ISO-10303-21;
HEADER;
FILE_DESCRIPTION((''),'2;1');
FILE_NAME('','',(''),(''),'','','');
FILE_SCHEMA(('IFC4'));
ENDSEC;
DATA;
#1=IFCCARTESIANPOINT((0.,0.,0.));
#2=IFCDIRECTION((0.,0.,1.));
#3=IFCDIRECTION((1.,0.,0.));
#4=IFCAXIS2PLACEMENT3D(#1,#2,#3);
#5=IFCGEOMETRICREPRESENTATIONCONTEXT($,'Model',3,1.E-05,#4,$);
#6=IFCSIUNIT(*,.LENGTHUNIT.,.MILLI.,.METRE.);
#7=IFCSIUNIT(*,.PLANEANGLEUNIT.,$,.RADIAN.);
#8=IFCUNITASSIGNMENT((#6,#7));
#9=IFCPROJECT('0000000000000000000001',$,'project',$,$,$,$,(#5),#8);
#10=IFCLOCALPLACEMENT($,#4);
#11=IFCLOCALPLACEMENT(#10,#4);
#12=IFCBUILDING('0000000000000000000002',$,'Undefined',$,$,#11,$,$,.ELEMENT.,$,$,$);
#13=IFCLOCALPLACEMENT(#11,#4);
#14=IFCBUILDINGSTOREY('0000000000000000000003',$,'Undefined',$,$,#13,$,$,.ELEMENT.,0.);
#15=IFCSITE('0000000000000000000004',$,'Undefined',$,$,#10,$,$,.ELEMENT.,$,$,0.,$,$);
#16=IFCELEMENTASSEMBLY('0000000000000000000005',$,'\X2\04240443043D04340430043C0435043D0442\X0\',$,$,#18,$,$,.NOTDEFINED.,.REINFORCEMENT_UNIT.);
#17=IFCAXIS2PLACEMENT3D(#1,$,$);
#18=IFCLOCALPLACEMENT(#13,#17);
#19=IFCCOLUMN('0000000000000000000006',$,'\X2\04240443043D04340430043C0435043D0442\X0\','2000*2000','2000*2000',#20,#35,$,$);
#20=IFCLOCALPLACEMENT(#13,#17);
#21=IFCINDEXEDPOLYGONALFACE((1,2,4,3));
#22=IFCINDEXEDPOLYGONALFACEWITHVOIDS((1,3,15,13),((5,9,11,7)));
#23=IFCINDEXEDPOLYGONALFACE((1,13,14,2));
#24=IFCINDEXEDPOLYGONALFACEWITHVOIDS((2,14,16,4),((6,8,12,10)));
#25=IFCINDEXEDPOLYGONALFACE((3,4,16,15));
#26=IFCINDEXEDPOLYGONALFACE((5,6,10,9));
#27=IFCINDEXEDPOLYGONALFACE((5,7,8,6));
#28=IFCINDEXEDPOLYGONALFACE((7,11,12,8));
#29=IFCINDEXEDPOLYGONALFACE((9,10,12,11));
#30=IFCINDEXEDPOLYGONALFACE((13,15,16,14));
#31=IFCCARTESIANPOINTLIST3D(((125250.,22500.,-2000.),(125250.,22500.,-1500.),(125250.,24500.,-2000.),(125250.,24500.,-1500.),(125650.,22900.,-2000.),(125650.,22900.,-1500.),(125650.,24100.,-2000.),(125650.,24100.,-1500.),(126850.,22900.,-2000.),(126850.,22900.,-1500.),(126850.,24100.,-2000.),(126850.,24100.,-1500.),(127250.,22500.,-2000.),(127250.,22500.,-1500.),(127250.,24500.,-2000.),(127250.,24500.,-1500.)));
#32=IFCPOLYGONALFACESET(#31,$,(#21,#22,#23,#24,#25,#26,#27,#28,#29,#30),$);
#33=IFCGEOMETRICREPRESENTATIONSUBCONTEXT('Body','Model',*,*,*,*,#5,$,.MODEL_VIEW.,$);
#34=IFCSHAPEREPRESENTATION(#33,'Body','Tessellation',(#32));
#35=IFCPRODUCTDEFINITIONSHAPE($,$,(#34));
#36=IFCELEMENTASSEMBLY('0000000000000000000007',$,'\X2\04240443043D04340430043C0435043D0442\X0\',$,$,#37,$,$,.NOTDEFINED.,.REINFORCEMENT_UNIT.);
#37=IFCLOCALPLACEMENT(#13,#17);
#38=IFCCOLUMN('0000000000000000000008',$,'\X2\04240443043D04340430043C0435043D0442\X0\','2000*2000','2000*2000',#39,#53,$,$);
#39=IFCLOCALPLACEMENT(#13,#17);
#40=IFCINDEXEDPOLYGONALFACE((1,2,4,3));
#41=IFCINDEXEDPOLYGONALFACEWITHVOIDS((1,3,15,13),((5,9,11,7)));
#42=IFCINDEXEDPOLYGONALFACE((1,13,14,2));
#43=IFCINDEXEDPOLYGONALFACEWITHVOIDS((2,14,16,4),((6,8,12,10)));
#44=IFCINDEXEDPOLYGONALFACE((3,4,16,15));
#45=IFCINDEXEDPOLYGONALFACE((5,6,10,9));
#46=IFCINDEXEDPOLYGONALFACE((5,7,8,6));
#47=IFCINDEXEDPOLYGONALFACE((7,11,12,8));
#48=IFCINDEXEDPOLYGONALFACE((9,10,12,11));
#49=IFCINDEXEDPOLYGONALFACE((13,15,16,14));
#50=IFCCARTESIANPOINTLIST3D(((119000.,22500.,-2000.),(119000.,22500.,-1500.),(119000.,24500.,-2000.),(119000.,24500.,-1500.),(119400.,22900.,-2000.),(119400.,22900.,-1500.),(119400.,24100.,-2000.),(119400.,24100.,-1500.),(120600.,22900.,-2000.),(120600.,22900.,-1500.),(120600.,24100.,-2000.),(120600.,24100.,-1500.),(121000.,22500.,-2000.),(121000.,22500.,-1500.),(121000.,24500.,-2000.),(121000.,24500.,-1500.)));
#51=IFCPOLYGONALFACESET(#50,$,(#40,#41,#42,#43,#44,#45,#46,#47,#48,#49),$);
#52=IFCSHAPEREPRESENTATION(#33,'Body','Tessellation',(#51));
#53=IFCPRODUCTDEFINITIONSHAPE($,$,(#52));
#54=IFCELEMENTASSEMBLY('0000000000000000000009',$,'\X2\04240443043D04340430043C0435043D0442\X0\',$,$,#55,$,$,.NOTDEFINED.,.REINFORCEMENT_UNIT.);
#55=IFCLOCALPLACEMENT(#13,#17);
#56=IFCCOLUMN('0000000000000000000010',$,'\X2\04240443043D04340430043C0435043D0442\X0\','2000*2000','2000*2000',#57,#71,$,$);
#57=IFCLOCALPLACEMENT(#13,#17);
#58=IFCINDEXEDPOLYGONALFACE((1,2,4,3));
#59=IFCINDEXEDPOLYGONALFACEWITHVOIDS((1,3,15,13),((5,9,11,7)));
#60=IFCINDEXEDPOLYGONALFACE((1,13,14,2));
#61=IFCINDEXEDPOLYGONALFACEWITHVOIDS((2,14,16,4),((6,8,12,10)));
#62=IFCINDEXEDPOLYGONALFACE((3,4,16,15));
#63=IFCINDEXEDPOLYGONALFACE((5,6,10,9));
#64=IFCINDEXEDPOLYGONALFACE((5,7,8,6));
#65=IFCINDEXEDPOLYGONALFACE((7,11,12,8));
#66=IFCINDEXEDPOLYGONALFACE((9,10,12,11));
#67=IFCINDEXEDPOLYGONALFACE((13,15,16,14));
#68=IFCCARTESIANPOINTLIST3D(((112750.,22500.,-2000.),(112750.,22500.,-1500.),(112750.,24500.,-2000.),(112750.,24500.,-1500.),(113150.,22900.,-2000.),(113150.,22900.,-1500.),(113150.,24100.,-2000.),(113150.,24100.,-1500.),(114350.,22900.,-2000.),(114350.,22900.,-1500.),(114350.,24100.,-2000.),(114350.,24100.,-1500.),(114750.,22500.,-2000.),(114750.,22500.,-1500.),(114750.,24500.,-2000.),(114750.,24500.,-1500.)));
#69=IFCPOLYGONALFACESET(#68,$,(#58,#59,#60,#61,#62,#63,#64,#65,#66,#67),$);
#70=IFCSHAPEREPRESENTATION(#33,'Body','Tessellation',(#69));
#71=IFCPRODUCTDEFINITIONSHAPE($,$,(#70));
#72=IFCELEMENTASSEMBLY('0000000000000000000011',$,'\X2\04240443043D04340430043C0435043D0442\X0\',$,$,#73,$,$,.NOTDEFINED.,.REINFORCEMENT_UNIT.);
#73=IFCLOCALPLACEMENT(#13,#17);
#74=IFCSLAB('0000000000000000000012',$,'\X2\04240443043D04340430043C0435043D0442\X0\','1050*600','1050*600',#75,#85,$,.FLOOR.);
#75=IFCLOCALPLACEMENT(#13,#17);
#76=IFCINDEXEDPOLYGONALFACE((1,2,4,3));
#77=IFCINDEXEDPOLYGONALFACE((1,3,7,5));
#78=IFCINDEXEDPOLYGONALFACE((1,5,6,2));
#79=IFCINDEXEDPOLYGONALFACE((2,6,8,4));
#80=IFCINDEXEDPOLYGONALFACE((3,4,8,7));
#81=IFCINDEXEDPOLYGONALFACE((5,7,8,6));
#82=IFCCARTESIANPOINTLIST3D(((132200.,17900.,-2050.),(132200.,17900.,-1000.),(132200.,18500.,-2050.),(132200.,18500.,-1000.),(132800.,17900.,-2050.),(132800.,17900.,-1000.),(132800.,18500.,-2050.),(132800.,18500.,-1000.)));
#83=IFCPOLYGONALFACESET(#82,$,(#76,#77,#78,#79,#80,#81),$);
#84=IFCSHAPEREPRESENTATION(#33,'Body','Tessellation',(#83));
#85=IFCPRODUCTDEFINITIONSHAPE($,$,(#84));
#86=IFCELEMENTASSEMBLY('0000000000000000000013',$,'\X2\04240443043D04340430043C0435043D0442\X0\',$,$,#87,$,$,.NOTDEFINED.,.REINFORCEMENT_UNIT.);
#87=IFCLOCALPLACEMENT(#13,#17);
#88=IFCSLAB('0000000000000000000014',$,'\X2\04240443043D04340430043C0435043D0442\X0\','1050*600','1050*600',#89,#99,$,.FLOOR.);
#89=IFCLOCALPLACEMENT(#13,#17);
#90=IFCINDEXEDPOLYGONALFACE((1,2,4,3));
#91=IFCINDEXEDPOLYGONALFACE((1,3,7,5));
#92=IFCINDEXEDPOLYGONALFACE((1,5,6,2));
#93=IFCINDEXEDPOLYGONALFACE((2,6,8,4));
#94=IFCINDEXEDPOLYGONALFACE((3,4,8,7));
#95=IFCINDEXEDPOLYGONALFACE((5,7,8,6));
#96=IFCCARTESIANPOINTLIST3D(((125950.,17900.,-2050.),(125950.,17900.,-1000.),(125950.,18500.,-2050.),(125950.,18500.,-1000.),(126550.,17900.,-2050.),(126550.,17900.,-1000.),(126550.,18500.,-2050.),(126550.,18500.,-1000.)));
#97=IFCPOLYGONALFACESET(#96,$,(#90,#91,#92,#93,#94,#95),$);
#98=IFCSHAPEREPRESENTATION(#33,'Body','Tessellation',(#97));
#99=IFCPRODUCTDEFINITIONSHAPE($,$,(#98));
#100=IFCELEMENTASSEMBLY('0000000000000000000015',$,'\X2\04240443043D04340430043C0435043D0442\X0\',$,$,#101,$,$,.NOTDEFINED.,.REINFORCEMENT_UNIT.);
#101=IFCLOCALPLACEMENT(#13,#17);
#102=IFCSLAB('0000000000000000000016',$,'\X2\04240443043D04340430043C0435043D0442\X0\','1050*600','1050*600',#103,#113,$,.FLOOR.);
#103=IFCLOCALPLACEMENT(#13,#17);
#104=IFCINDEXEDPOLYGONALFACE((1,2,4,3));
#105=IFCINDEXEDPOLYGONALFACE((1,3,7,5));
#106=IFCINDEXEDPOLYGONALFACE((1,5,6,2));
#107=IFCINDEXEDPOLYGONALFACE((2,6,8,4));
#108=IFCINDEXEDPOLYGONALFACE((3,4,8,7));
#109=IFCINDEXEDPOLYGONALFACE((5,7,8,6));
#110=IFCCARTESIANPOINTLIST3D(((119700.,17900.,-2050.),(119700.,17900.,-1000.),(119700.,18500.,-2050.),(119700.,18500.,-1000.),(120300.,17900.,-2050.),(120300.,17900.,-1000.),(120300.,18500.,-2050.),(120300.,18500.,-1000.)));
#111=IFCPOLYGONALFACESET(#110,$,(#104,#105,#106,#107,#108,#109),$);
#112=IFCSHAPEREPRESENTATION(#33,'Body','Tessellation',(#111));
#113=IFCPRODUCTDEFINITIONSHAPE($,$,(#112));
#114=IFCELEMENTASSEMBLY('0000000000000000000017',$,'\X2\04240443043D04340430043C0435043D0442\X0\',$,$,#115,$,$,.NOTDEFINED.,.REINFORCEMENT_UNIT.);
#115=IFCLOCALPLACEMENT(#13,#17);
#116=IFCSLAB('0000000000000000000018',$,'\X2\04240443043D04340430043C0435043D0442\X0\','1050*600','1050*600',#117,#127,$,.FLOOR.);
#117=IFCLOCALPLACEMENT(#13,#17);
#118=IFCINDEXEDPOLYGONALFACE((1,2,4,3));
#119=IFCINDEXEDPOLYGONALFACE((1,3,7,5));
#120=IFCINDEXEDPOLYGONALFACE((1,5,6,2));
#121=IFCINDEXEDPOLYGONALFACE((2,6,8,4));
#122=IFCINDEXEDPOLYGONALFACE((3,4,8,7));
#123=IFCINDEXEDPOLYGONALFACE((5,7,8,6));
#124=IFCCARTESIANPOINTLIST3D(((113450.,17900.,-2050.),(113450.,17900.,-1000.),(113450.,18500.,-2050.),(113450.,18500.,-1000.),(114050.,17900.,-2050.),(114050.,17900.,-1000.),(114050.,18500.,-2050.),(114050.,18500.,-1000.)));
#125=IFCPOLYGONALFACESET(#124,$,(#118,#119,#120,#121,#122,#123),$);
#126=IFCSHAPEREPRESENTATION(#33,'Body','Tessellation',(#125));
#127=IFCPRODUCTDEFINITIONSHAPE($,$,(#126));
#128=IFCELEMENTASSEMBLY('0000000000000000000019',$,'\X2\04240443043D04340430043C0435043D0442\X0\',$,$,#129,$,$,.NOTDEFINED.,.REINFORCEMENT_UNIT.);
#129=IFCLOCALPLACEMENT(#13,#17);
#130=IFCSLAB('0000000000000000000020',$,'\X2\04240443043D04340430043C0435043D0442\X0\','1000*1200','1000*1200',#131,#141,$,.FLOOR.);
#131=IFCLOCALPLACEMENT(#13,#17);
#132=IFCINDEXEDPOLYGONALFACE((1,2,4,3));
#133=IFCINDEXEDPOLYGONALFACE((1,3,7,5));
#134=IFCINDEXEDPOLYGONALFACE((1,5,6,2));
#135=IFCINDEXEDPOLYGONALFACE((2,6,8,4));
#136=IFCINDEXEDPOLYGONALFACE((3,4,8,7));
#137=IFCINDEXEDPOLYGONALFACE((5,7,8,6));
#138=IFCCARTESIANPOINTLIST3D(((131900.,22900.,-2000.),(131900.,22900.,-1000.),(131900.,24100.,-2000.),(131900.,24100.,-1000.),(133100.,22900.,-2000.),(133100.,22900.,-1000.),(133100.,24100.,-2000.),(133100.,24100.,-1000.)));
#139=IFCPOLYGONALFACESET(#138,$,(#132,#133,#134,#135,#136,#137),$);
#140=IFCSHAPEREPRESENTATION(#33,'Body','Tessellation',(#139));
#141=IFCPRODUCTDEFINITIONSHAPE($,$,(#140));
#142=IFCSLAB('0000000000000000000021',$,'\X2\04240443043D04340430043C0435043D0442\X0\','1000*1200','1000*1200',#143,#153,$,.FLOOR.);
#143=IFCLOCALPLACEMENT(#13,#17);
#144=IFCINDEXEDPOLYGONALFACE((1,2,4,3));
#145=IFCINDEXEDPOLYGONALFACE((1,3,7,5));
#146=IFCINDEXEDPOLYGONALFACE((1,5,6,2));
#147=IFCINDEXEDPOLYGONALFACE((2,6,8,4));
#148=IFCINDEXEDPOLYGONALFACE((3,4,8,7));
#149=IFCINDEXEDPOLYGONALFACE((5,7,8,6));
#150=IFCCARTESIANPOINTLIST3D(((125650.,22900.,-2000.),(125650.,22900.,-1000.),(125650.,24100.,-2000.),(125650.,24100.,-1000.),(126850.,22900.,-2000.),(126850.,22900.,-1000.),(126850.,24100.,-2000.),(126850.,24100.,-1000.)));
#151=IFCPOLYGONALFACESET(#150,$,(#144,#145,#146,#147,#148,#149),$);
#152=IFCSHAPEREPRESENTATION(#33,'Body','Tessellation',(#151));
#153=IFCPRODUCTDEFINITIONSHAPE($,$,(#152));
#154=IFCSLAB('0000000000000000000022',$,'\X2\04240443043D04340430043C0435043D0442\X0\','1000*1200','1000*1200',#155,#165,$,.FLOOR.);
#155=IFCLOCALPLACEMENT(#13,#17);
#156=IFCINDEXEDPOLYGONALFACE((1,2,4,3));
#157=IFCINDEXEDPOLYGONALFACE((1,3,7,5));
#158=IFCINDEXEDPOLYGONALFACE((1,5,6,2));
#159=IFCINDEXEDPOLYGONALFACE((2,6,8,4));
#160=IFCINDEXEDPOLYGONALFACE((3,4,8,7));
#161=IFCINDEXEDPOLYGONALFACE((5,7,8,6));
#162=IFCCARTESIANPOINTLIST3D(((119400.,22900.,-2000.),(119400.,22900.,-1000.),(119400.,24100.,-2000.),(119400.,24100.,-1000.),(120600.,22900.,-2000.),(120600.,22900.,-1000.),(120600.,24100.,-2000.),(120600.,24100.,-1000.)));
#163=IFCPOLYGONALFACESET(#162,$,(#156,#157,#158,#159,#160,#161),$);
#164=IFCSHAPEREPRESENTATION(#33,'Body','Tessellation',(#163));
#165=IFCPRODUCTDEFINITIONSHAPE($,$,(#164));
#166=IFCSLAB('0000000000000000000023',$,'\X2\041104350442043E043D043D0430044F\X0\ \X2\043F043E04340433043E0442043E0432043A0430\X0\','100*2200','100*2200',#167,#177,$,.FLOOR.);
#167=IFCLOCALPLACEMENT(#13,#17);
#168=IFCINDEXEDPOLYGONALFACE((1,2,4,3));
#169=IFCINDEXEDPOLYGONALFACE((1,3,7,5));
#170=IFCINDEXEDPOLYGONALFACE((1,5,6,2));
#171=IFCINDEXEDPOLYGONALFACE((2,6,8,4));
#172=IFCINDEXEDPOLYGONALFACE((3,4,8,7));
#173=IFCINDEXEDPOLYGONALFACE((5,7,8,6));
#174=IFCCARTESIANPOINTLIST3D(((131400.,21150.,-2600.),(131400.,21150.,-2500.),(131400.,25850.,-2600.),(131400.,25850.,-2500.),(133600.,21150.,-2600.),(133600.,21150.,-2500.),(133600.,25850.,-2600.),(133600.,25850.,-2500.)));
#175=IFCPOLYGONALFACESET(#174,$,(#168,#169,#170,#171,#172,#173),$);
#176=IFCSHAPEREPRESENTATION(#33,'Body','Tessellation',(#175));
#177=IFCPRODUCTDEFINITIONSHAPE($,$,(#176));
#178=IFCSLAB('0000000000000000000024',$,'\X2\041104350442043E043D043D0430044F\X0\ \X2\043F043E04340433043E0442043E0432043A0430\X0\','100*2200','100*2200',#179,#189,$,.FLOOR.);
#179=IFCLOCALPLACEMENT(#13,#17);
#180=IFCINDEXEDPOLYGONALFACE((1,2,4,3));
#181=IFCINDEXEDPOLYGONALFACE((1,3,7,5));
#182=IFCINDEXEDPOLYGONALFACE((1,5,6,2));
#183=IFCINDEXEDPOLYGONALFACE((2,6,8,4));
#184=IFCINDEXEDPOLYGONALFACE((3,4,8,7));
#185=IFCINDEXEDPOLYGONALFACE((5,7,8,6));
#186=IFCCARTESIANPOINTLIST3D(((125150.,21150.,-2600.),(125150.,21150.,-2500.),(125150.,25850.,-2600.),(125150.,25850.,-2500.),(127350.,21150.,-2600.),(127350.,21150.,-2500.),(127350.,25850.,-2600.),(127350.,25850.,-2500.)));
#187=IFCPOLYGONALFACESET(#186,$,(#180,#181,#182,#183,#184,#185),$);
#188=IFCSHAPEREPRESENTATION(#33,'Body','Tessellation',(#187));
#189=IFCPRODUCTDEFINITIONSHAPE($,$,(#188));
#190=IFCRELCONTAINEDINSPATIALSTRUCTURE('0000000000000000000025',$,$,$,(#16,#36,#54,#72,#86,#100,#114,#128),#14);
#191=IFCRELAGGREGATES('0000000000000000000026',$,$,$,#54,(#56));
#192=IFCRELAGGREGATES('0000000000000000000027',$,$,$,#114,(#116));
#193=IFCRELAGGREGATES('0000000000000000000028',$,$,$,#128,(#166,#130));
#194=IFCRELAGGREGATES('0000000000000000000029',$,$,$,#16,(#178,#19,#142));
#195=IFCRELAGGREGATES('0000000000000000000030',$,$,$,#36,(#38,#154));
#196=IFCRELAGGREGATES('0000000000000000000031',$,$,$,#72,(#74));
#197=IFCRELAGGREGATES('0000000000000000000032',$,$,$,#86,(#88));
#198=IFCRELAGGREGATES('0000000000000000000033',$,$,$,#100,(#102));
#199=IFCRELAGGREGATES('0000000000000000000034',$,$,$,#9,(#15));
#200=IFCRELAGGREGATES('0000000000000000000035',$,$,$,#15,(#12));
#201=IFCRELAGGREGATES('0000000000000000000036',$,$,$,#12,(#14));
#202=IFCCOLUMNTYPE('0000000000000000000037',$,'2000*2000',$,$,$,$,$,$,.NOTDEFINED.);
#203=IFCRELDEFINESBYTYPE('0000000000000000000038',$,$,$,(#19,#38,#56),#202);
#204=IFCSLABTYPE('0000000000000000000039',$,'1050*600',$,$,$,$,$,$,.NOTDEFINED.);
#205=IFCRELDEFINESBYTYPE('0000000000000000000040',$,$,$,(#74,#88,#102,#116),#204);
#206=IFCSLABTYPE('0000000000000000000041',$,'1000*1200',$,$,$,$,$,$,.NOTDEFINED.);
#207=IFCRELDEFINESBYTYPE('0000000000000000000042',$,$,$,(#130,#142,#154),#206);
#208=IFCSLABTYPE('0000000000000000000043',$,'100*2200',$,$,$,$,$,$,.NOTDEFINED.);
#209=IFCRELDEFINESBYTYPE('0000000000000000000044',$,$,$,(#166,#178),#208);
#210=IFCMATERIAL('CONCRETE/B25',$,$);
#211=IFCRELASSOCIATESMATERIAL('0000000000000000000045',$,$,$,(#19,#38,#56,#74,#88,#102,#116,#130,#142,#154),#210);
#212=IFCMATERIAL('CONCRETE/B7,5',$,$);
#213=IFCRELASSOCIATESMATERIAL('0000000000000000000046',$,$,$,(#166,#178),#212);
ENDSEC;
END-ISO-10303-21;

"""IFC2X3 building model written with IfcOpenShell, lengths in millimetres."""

from ifc_helpers import new_model, si_unit, frame, origin_with_axes, origin_2d_with_axis, place, context, subcontext, project, spatial, polyline, rectangle, outline, extrude, boolean, material, type_object, element, aggregate, save


model = new_model("IFC2X3")

# Units and contexts
model_context = context("Model", 3, precision=1e-05, world=origin_with_axes())
body_context = subcontext(model_context, "Body", "Model", "MODEL_VIEW")
ifc_project = project(units=[si_unit("LENGTHUNIT", "METRE", prefix="MILLI"), si_unit("PLANEANGLEUNIT", "RADIAN")], contexts=[model_context])

# Site, building, storey
site_placement = place(None, origin_with_axes())
site = spatial("IfcSite", under=ifc_project, at=site_placement, Name="Undefined", CompositionType="ELEMENT", RefElevation=0.0)
building_placement = place(site_placement, origin_with_axes())
building = spatial("IfcBuilding", under=site, at=building_placement, Name="Undefined", CompositionType="ELEMENT")
storey_placement = place(building_placement, origin_with_axes())
storey = spatial("IfcBuildingStorey", under=building, at=storey_placement, Name="Undefined", CompositionType="ELEMENT", Elevation=0.0)

# Element assemblies, columns
assembly_1_placement = place(storey_placement, origin_with_axes())
assembly_1 = element("IfcElementAssembly", 1, at=assembly_1_placement, inside=storey, Name="Фундамент", AssemblyPlace="NOTDEFINED", PredefinedType="REINFORCEMENT_UNIT")
ifc_material_1 = material(Name="CONCRETE/B25")
column_type = type_object("IfcColumnType", Name="2000*2000", PredefinedType="NOTDEFINED")
column_1_placement = place(assembly_1_placement, frame((126250.0, 23500.0, -2000.0), z_axis=(0.0, 0.0, 1.0), x_axis=(0.0, -1.0, 0.0)))
column_1 = element("IfcColumn", 2, at=column_1_placement, type_object=column_type, material=ifc_material_1, Name="Фундамент", Description="2000*2000", ObjectType="2000*2000", context=body_context, shape_type="CSG", body=[
    boolean("DIFFERENCE", extrude(rectangle(XDim=2000.0, YDim=2000.0, at=origin_2d_with_axis()), frame((0.0, 0.0, 500.0), z_axis=(0.0, 0.0, -1.0), x_axis=(0.0, 1.0, 0.0)), (0.0, 0.0, 1.0), 500.0), extrude(outline(polyline([(0.0, 0.0), (1200.0, 0.0), (1200.0, 1200.0), (0.0, 1200.0), (0.0, 0.0)])), frame((-600.0, -600.0, -100.0), z_axis=(0.0, 0.0, 1.0), x_axis=(1.0, 0.0, 0.0)), (0.0, 0.0, 1.0), 700.0)),
])
assembly_2_placement = place(storey_placement, origin_with_axes())
assembly_2 = element("IfcElementAssembly", 3, at=assembly_2_placement, inside=storey, Name="Фундамент", AssemblyPlace="NOTDEFINED", PredefinedType="REINFORCEMENT_UNIT")
column_2_placement = place(assembly_2_placement, frame((120000.0, 23500.0, -2000.0), z_axis=(0.0, 0.0, 1.0), x_axis=(0.0, -1.0, 0.0)))
column_2 = element("IfcColumn", 4, at=column_2_placement, type_object=column_type, material=ifc_material_1, Name="Фундамент", Description="2000*2000", ObjectType="2000*2000", context=body_context, shape_type="CSG", body=[
    boolean("DIFFERENCE", extrude(rectangle(XDim=2000.0, YDim=2000.0, at=origin_2d_with_axis()), frame((0.0, 0.0, 500.0), z_axis=(0.0, 0.0, -1.0), x_axis=(0.0, 1.0, 0.0)), (0.0, 0.0, 1.0), 500.0), extrude(outline(polyline([(0.0, 0.0), (1200.0, 0.0), (1200.0, 1200.0), (0.0, 1200.0), (0.0, 0.0)])), frame((-600.0, -600.0, -100.0), z_axis=(0.0, 0.0, 1.0), x_axis=(1.0, 0.0, 0.0)), (0.0, 0.0, 1.0), 700.0)),
])
assembly_3_placement = place(storey_placement, origin_with_axes())
assembly_3 = element("IfcElementAssembly", 5, at=assembly_3_placement, inside=storey, Name="Фундамент", AssemblyPlace="NOTDEFINED", PredefinedType="REINFORCEMENT_UNIT")
column_3_placement = place(assembly_3_placement, frame((113750.0, 23500.0, -2000.0), z_axis=(0.0, 0.0, 1.0), x_axis=(0.0, -1.0, 0.0)))
column_3 = element("IfcColumn", 6, at=column_3_placement, type_object=column_type, material=ifc_material_1, Name="Фундамент", Description="2000*2000", ObjectType="2000*2000", context=body_context, shape_type="CSG", body=[
    boolean("DIFFERENCE", extrude(rectangle(XDim=2000.0, YDim=2000.0, at=origin_2d_with_axis()), frame((0.0, 0.0, 500.0), z_axis=(0.0, 0.0, -1.0), x_axis=(0.0, 1.0, 0.0)), (0.0, 0.0, 1.0), 500.0), extrude(outline(polyline([(0.0, 0.0), (1200.0, 0.0), (1200.0, 1200.0), (0.0, 1200.0), (0.0, 0.0)])), frame((-600.0, -600.0, -100.0), z_axis=(0.0, 0.0, 1.0), x_axis=(1.0, 0.0, 0.0)), (0.0, 0.0, 1.0), 700.0)),
])
aggregate(assembly_3, [column_3])

# Element assemblies, slabs
assembly_4_placement = place(storey_placement, origin_with_axes())
assembly_4 = element("IfcElementAssembly", 7, at=assembly_4_placement, inside=storey, Name="Фундамент", AssemblyPlace="NOTDEFINED", PredefinedType="REINFORCEMENT_UNIT")
slab_type_1 = type_object("IfcSlabType", Name="1050*600", PredefinedType="NOTDEFINED")
slab_1_placement = place(assembly_4_placement, frame((132200.0, 18500.0, -1525.0), z_axis=(0.0, 0.0, 1.0), x_axis=(0.0, -1.0, 0.0)))
slab_1 = element("IfcSlab", 8, at=slab_1_placement, type_object=slab_type_1, material=ifc_material_1, Name="Фундамент", Description="1050*600", ObjectType="1050*600", PredefinedType="FLOOR", context=body_context, shape_type="SweptSolid", body=[
    extrude(outline(polyline([(0.0, 0.0), (600.0, 0.0), (600.0, 600.0), (0.0, 600.0), (0.0, 0.0)])), frame((0.0, 0.0, -525.0), z_axis=(0.0, 0.0, 1.0), x_axis=(1.0, 0.0, 0.0)), (0.0, 0.0, 1.0), 1050.0),
])
assembly_5_placement = place(storey_placement, origin_with_axes())
assembly_5 = element("IfcElementAssembly", 9, at=assembly_5_placement, inside=storey, Name="Фундамент", AssemblyPlace="NOTDEFINED", PredefinedType="REINFORCEMENT_UNIT")
slab_2_placement = place(assembly_5_placement, frame((125950.0, 18500.0, -1525.0), z_axis=(0.0, 0.0, 1.0), x_axis=(0.0, -1.0, 0.0)))
slab_2 = element("IfcSlab", 10, at=slab_2_placement, type_object=slab_type_1, material=ifc_material_1, Name="Фундамент", Description="1050*600", ObjectType="1050*600", PredefinedType="FLOOR", context=body_context, shape_type="SweptSolid", body=[
    extrude(outline(polyline([(0.0, 0.0), (600.0, 0.0), (600.0, 600.0), (0.0, 600.0), (0.0, 0.0)])), frame((0.0, 0.0, -525.0), z_axis=(0.0, 0.0, 1.0), x_axis=(1.0, 0.0, 0.0)), (0.0, 0.0, 1.0), 1050.0),
])
assembly_6_placement = place(storey_placement, origin_with_axes())
assembly_6 = element("IfcElementAssembly", 11, at=assembly_6_placement, inside=storey, Name="Фундамент", AssemblyPlace="NOTDEFINED", PredefinedType="REINFORCEMENT_UNIT")
slab_3_placement = place(assembly_6_placement, frame((119700.0, 18500.0, -1525.0), z_axis=(0.0, 0.0, 1.0), x_axis=(0.0, -1.0, 0.0)))
slab_3 = element("IfcSlab", 12, at=slab_3_placement, type_object=slab_type_1, material=ifc_material_1, Name="Фундамент", Description="1050*600", ObjectType="1050*600", PredefinedType="FLOOR", context=body_context, shape_type="SweptSolid", body=[
    extrude(outline(polyline([(0.0, 0.0), (600.0, 0.0), (600.0, 600.0), (0.0, 600.0), (0.0, 0.0)])), frame((0.0, 0.0, -525.0), z_axis=(0.0, 0.0, 1.0), x_axis=(1.0, 0.0, 0.0)), (0.0, 0.0, 1.0), 1050.0),
])
assembly_7_placement = place(storey_placement, origin_with_axes())
assembly_7 = element("IfcElementAssembly", 13, at=assembly_7_placement, inside=storey, Name="Фундамент", AssemblyPlace="NOTDEFINED", PredefinedType="REINFORCEMENT_UNIT")
slab_4_placement = place(assembly_7_placement, frame((113450.0, 18500.0, -1525.0), z_axis=(0.0, 0.0, 1.0), x_axis=(0.0, -1.0, 0.0)))
slab_4 = element("IfcSlab", 14, at=slab_4_placement, type_object=slab_type_1, material=ifc_material_1, Name="Фундамент", Description="1050*600", ObjectType="1050*600", PredefinedType="FLOOR", context=body_context, shape_type="SweptSolid", body=[
    extrude(outline(polyline([(0.0, 0.0), (600.0, 0.0), (600.0, 600.0), (0.0, 600.0), (0.0, 0.0)])), frame((0.0, 0.0, -525.0), z_axis=(0.0, 0.0, 1.0), x_axis=(1.0, 0.0, 0.0)), (0.0, 0.0, 1.0), 1050.0),
])
aggregate(assembly_7, [slab_4])
assembly_8_placement = place(storey_placement, origin_with_axes())
assembly_8 = element("IfcElementAssembly", 15, at=assembly_8_placement, inside=storey, Name="Фундамент", AssemblyPlace="NOTDEFINED", PredefinedType="REINFORCEMENT_UNIT")
slab_type_2 = type_object("IfcSlabType", Name="1000*1200", PredefinedType="NOTDEFINED")
slab_5_placement = place(assembly_8_placement, frame((131900.0, 24100.0, -1500.0), z_axis=(0.0, 0.0, 1.0), x_axis=(0.0, -1.0, 0.0)))
slab_5 = element("IfcSlab", 16, at=slab_5_placement, type_object=slab_type_2, material=ifc_material_1, Name="Фундамент", Description="1000*1200", ObjectType="1000*1200", PredefinedType="FLOOR", context=body_context, shape_type="SweptSolid", body=[
    extrude(outline(polyline([(0.0, 0.0), (1200.0, 0.0), (1200.0, 1200.0), (0.0, 1200.0), (0.0, 0.0)])), frame((0.0, 0.0, -500.0), z_axis=(0.0, 0.0, 1.0), x_axis=(1.0, 0.0, 0.0)), (0.0, 0.0, 1.0), 1000.0),
])

# Slabs
slab_6_placement = place(assembly_1_placement, frame((125650.0, 24100.0, -1500.0), z_axis=(0.0, 0.0, 1.0), x_axis=(0.0, -1.0, 0.0)))
slab_6 = element("IfcSlab", 17, at=slab_6_placement, type_object=slab_type_2, material=ifc_material_1, Name="Фундамент", Description="1000*1200", ObjectType="1000*1200", PredefinedType="FLOOR", context=body_context, shape_type="SweptSolid", body=[
    extrude(outline(polyline([(0.0, 0.0), (1200.0, 0.0), (1200.0, 1200.0), (0.0, 1200.0), (0.0, 0.0)])), frame((0.0, 0.0, -500.0), z_axis=(0.0, 0.0, 1.0), x_axis=(1.0, 0.0, 0.0)), (0.0, 0.0, 1.0), 1000.0),
])
slab_7_placement = place(assembly_2_placement, frame((119400.0, 24100.0, -1500.0), z_axis=(0.0, 0.0, 1.0), x_axis=(0.0, -1.0, 0.0)))
slab_7 = element("IfcSlab", 18, at=slab_7_placement, type_object=slab_type_2, material=ifc_material_1, Name="Фундамент", Description="1000*1200", ObjectType="1000*1200", PredefinedType="FLOOR", context=body_context, shape_type="SweptSolid", body=[
    extrude(outline(polyline([(0.0, 0.0), (1200.0, 0.0), (1200.0, 1200.0), (0.0, 1200.0), (0.0, 0.0)])), frame((0.0, 0.0, -500.0), z_axis=(0.0, 0.0, 1.0), x_axis=(1.0, 0.0, 0.0)), (0.0, 0.0, 1.0), 1000.0),
])
ifc_material_2 = material(Name="CONCRETE/B7,5")
slab_type_3 = type_object("IfcSlabType", Name="100*2200", PredefinedType="NOTDEFINED")
slab_8_placement = place(assembly_8_placement, frame((131400.0, 25850.0, -2550.0), z_axis=(0.0, 0.0, 1.0), x_axis=(0.0, -1.0, 0.0)))
slab_8 = element("IfcSlab", 19, at=slab_8_placement, type_object=slab_type_3, material=ifc_material_2, Name="Бетонная подготовка", Description="100*2200", ObjectType="100*2200", PredefinedType="FLOOR", context=body_context, shape_type="SweptSolid", body=[
    extrude(outline(polyline([(0.0, 0.0), (4700.0, 0.0), (4700.0, 2200.0), (0.0, 2200.0), (0.0, 0.0)])), frame((0.0, 0.0, -50.0), z_axis=(0.0, 0.0, 1.0), x_axis=(1.0, 0.0, 0.0)), (0.0, 0.0, 1.0), 100.0),
])
slab_9_placement = place(assembly_1_placement, frame((125150.0, 25850.0, -2550.0), z_axis=(0.0, 0.0, 1.0), x_axis=(0.0, -1.0, 0.0)))
slab_9 = element("IfcSlab", 20, at=slab_9_placement, type_object=slab_type_3, material=ifc_material_2, Name="Бетонная подготовка", Description="100*2200", ObjectType="100*2200", PredefinedType="FLOOR", context=body_context, shape_type="SweptSolid", body=[
    extrude(outline(polyline([(0.0, 0.0), (4700.0, 0.0), (4700.0, 2200.0), (0.0, 2200.0), (0.0, 0.0)])), frame((0.0, 0.0, -50.0), z_axis=(0.0, 0.0, 1.0), x_axis=(1.0, 0.0, 0.0)), (0.0, 0.0, 1.0), 100.0),
])
aggregate(assembly_8, [slab_8, slab_5])
aggregate(assembly_1, [slab_9, column_1, slab_6])
aggregate(assembly_2, [column_2, slab_7])
aggregate(assembly_4, [slab_1])
aggregate(assembly_5, [slab_2])
aggregate(assembly_6, [slab_3])

save(model, "model.ifc")
